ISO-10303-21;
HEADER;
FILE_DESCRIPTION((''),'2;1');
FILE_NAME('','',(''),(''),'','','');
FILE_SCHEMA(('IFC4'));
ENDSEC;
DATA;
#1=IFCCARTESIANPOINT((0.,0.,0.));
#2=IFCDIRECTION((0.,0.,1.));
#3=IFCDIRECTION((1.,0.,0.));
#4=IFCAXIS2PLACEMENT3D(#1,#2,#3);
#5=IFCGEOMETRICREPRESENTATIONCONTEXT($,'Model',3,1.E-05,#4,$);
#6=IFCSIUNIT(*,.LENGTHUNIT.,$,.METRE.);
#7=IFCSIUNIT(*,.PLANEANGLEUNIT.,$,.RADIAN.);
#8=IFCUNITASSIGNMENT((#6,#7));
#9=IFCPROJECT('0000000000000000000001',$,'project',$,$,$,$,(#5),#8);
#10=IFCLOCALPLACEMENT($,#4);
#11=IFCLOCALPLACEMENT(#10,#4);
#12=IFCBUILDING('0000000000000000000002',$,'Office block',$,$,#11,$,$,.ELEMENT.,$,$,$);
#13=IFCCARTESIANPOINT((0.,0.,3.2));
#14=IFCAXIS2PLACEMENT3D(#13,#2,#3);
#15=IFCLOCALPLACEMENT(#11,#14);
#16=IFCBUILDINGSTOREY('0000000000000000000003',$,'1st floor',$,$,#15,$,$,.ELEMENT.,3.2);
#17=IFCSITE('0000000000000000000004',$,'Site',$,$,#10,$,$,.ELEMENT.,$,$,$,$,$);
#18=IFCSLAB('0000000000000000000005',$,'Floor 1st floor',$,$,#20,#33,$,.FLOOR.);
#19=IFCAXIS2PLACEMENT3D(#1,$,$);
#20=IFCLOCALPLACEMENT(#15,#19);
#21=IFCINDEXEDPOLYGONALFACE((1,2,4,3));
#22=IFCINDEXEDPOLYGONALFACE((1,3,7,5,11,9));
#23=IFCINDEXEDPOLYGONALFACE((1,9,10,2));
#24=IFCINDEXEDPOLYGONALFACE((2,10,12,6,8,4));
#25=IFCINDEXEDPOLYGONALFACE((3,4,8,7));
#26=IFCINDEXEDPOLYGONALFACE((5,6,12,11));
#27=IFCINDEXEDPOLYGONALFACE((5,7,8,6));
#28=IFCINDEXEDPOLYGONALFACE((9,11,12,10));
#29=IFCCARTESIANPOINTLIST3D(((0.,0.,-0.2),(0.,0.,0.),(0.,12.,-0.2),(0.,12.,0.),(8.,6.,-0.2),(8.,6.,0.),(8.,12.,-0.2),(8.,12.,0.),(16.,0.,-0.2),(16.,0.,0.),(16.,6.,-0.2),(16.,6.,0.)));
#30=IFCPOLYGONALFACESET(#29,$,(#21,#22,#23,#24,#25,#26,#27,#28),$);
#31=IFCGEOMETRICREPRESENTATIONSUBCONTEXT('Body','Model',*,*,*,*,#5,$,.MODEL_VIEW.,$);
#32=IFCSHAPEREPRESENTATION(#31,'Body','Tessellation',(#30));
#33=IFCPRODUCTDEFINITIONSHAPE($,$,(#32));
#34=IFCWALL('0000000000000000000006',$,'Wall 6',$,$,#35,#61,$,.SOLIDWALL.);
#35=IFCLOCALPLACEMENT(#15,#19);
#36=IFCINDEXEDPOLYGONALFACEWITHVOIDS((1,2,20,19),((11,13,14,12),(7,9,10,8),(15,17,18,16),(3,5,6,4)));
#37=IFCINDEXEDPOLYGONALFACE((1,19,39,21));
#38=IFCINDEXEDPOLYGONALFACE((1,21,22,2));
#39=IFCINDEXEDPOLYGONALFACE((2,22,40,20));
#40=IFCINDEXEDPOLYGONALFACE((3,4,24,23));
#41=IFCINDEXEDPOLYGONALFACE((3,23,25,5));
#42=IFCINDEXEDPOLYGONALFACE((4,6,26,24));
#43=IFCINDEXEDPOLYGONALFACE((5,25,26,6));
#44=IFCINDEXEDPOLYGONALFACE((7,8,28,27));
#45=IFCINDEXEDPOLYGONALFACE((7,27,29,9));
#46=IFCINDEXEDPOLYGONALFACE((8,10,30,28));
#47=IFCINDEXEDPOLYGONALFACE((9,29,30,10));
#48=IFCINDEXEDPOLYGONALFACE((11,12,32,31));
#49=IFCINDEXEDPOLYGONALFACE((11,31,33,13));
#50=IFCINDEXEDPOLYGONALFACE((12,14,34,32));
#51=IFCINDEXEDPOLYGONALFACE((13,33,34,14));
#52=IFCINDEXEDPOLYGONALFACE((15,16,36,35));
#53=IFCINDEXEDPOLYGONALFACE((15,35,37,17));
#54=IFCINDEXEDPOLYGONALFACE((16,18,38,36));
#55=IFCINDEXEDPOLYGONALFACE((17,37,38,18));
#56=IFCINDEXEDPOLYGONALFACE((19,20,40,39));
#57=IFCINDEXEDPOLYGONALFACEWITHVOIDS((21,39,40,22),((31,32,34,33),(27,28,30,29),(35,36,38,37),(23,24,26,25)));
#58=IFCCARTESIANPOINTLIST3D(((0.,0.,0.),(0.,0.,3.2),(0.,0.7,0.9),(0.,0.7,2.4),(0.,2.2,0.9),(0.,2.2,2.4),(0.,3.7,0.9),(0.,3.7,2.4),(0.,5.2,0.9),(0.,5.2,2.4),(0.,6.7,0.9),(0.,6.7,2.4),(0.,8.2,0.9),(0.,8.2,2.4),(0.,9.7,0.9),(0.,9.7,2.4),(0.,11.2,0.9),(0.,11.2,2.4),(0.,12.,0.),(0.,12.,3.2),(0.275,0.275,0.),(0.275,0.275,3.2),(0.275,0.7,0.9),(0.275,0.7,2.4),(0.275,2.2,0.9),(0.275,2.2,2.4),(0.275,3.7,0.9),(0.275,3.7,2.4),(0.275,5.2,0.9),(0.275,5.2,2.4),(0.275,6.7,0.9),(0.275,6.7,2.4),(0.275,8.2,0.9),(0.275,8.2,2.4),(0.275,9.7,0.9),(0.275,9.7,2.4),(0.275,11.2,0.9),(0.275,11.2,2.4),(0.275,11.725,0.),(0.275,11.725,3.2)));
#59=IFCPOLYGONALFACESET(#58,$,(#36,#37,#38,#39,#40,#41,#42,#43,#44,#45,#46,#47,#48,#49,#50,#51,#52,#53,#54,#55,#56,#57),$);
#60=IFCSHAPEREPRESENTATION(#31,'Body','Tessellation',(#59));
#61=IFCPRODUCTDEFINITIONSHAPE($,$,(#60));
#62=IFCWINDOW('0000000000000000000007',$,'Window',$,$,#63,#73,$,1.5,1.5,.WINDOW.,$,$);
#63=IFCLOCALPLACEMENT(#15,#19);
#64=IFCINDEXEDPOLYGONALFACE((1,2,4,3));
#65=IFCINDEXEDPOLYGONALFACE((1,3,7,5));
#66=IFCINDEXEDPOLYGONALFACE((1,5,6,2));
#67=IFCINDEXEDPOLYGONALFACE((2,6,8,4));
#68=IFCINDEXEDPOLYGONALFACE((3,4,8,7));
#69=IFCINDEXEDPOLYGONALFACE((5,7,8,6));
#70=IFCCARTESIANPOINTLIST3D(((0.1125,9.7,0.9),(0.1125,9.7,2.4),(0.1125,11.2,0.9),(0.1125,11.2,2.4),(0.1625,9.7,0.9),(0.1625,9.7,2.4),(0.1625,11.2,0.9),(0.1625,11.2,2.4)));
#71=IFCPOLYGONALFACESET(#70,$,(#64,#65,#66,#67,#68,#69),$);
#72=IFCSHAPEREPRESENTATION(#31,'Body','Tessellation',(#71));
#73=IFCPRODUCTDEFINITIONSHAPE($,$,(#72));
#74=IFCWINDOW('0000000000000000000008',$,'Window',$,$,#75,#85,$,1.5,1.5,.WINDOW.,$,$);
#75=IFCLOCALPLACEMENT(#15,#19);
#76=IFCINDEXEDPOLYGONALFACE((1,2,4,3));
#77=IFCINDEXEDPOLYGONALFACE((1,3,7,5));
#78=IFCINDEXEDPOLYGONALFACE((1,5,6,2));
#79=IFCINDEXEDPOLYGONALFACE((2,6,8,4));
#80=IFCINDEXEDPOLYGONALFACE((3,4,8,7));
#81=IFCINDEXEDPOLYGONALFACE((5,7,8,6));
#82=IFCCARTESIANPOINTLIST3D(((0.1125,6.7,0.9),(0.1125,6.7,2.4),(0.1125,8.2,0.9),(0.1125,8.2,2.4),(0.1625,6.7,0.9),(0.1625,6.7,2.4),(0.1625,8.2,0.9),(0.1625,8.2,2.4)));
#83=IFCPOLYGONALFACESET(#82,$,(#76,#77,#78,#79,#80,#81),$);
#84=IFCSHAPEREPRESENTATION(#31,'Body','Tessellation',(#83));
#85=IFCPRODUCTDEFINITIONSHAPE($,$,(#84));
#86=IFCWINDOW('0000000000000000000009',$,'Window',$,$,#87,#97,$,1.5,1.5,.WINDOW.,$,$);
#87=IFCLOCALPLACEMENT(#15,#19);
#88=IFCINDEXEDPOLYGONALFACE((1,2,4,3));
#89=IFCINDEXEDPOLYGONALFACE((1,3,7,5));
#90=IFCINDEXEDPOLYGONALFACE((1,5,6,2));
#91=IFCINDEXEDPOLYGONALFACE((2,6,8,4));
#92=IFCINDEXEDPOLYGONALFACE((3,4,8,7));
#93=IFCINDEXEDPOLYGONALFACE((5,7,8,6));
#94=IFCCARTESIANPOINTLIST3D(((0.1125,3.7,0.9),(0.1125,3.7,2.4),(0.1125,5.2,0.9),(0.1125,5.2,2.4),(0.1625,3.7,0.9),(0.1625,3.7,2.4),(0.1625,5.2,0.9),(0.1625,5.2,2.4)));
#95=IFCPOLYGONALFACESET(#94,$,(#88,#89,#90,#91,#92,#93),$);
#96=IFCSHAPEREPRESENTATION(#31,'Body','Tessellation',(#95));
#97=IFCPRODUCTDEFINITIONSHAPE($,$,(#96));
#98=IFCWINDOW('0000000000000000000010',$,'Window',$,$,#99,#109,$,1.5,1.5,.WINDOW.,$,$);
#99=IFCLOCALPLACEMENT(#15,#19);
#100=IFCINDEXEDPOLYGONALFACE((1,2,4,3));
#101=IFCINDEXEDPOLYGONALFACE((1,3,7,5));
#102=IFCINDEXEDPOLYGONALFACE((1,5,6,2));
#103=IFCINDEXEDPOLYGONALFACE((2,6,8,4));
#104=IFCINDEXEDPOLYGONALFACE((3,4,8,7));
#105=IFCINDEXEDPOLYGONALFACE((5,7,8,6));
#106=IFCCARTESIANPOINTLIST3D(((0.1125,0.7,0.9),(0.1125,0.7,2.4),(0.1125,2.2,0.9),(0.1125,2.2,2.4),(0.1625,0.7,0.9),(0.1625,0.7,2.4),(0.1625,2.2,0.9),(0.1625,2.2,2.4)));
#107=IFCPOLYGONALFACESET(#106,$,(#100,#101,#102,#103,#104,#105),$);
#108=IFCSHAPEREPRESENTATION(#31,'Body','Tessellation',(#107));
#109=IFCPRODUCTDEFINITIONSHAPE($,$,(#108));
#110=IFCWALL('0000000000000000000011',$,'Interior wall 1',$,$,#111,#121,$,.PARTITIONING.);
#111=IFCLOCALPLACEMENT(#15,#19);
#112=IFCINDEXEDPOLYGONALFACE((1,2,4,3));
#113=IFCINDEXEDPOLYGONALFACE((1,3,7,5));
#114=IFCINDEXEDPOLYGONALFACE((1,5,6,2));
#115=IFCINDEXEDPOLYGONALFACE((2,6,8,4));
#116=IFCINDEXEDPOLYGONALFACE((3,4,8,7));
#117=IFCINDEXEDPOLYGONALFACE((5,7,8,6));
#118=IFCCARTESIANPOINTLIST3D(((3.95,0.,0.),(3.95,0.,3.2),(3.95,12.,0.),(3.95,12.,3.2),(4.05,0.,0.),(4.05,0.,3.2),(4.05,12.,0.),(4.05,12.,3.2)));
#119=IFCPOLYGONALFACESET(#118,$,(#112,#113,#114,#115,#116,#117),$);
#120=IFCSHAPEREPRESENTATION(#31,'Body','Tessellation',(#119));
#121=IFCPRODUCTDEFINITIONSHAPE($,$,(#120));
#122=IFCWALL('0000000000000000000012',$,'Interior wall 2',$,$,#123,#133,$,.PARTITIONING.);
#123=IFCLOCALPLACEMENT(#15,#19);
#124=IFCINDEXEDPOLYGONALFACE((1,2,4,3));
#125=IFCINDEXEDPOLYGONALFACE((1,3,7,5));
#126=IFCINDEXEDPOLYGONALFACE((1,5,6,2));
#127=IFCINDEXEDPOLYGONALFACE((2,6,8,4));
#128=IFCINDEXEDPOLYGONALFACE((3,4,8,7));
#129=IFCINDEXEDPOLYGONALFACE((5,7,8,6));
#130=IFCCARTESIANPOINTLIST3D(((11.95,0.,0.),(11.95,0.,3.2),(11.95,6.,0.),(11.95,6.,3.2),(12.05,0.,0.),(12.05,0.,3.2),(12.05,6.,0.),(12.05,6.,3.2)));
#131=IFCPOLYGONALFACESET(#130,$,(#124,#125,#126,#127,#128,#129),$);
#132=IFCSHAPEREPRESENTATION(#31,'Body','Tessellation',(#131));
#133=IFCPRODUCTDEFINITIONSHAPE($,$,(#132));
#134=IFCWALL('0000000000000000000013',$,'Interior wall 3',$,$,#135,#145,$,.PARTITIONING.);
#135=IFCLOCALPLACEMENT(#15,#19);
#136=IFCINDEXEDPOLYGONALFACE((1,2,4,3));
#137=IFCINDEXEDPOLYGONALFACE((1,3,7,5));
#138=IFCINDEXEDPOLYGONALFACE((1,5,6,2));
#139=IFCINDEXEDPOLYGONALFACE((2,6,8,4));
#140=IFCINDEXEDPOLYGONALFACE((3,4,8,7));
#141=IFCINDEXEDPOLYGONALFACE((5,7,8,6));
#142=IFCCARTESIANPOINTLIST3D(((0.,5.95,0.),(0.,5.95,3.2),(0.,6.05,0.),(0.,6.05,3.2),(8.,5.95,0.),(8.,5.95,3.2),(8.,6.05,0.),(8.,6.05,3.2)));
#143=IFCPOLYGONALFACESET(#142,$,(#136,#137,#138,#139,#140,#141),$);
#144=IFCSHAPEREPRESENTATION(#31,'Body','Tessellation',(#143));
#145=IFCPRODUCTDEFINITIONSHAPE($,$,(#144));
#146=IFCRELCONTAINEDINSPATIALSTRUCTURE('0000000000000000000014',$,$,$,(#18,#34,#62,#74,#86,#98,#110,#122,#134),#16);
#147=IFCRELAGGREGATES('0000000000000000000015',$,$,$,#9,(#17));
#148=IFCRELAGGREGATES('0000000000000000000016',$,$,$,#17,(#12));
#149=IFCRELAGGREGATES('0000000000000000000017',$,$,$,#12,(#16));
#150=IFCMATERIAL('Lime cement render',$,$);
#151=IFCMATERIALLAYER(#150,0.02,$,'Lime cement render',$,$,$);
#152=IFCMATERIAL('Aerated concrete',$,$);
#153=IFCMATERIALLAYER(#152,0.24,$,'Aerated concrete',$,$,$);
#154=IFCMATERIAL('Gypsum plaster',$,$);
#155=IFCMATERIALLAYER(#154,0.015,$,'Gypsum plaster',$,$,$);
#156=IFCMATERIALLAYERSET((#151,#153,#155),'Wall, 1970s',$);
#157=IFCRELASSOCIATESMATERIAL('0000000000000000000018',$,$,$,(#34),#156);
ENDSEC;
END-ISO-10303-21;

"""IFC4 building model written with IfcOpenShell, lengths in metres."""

from ifc_helpers import new_model, si_unit, frame, origin_with_axes, place, context, subcontext, project, spatial, polyline, outline, extrude, material, layer, layer_set, layer_usage, element, fill, save


model = new_model("IFC4")

# Units and contexts
model_context = context("Model", 3, precision=1e-05, world=origin_with_axes())
body_context = subcontext(model_context, "Body", "Model", "MODEL_VIEW")
ifc_project = project(units=[si_unit("LENGTHUNIT", "METRE"), si_unit("PLANEANGLEUNIT", "RADIAN")], contexts=[model_context])

# Site, building, storey
site_placement = place(None, origin_with_axes())
site = spatial("IfcSite", under=ifc_project, at=site_placement, Name="Site", CompositionType="ELEMENT")
building_placement = place(site_placement, origin_with_axes())
building = spatial("IfcBuilding", under=site, at=building_placement, Name="Office block", CompositionType="ELEMENT")
storey_placement = place(building_placement, frame((0.0, 0.0, 3.2), z_axis=(0.0, 0.0, 1.0), x_axis=(1.0, 0.0, 0.0)))
storey = spatial("IfcBuildingStorey", under=building, at=storey_placement, Name="1st floor", CompositionType="ELEMENT", Elevation=3.2)

# Slab
slab_placement = place(storey_placement, origin_with_axes())
element("IfcSlab", 1, at=slab_placement, inside=storey, Name="Floor 1st floor", PredefinedType="FLOOR", context=body_context, shape_type="SweptSolid", body=[
    extrude(outline(polyline([(0.0, 0.0), (16.0, 0.0), (16.0, 6.0), (8.0, 6.0), (8.0, 12.0), (0.0, 12.0), (0.0, 0.0)])), frame((0.0, 0.0, -0.2), z_axis=(0.0, 0.0, 1.0), x_axis=(1.0, 0.0, 0.0)), (0.0, 0.0, 1.0), 0.2),
])

# Wall, openings, windows
ifc_material_1 = material(Name="Lime cement render")
ifc_layer_1 = layer(ifc_material_1, 0.02, Name="Lime cement render")
ifc_material_2 = material(Name="Aerated concrete")
ifc_layer_2 = layer(ifc_material_2, 0.24, Name="Aerated concrete")
ifc_material_3 = material(Name="Gypsum plaster")
ifc_layer_3 = layer(ifc_material_3, 0.015, Name="Gypsum plaster")
ifc_layer_set = layer_set([ifc_layer_1, ifc_layer_2, ifc_layer_3], Name="Wall, 1970s")
ifc_layer_usage = layer_usage(ifc_layer_set, "AXIS2", "NEGATIVE", 0.0)
wall_1_placement = place(storey_placement, origin_with_axes())
wall_1 = element("IfcWall", 2, at=wall_1_placement, inside=storey, material=ifc_layer_usage, Name="Wall 6", PredefinedType="SOLIDWALL", context=body_context, shape_type="SweptSolid", body=[
    extrude(outline(polyline([(0.0, 12.0), (0.0, 0.0), (0.275, 0.275), (0.275, 11.725), (0.0, 12.0)])), origin_with_axes(), (0.0, 0.0, 1.0), 3.2),
])
opening_1_placement = place(storey_placement, origin_with_axes())
opening_1 = element("IfcOpeningElement", 3, at=opening_1_placement, cuts=wall_1, PredefinedType="OPENING", context=body_context, shape_type="SweptSolid", body=[
    extrude(outline(polyline([(-0.01, 11.2), (-0.01, 9.7), (0.285, 9.7), (0.285, 11.2), (-0.01, 11.2)])), frame((0.0, 0.0, 0.9), z_axis=(0.0, 0.0, 1.0), x_axis=(1.0, 0.0, 0.0)), (0.0, 0.0, 1.0), 1.5),
])
opening_2_placement = place(storey_placement, origin_with_axes())
opening_2 = element("IfcOpeningElement", 4, at=opening_2_placement, cuts=wall_1, PredefinedType="OPENING", context=body_context, shape_type="SweptSolid", body=[
    extrude(outline(polyline([(-0.01, 8.2), (-0.01, 6.7), (0.285, 6.7), (0.285, 8.2), (-0.01, 8.2)])), frame((0.0, 0.0, 0.9), z_axis=(0.0, 0.0, 1.0), x_axis=(1.0, 0.0, 0.0)), (0.0, 0.0, 1.0), 1.5),
])
opening_3_placement = place(storey_placement, origin_with_axes())
opening_3 = element("IfcOpeningElement", 5, at=opening_3_placement, cuts=wall_1, PredefinedType="OPENING", context=body_context, shape_type="SweptSolid", body=[
    extrude(outline(polyline([(-0.01, 5.2), (-0.01, 3.7), (0.285, 3.7), (0.285, 5.2), (-0.01, 5.2)])), frame((0.0, 0.0, 0.9), z_axis=(0.0, 0.0, 1.0), x_axis=(1.0, 0.0, 0.0)), (0.0, 0.0, 1.0), 1.5),
])
opening_4_placement = place(storey_placement, origin_with_axes())
opening_4 = element("IfcOpeningElement", 6, at=opening_4_placement, cuts=wall_1, PredefinedType="OPENING", context=body_context, shape_type="SweptSolid", body=[
    extrude(outline(polyline([(-0.01, 2.2), (-0.01, 0.7), (0.285, 0.7), (0.285, 2.2), (-0.01, 2.2)])), frame((0.0, 0.0, 0.9), z_axis=(0.0, 0.0, 1.0), x_axis=(1.0, 0.0, 0.0)), (0.0, 0.0, 1.0), 1.5),
])
window_1_placement = place(storey_placement, origin_with_axes())
window_1 = element("IfcWindow", 7, at=window_1_placement, inside=storey, Name="Window", OverallHeight=1.5, OverallWidth=1.5, PredefinedType="WINDOW", context=body_context, shape_type="SweptSolid", body=[
    extrude(outline(polyline([(0.1125, 11.2), (0.1125, 9.7), (0.1625, 9.7), (0.1625, 11.2), (0.1125, 11.2)])), frame((0.0, 0.0, 0.9), z_axis=(0.0, 0.0, 1.0), x_axis=(1.0, 0.0, 0.0)), (0.0, 0.0, 1.0), 1.5),
])
fill(opening_1, window_1)
window_2_placement = place(storey_placement, origin_with_axes())
window_2 = element("IfcWindow", 8, at=window_2_placement, inside=storey, Name="Window", OverallHeight=1.5, OverallWidth=1.5, PredefinedType="WINDOW", context=body_context, shape_type="SweptSolid", body=[
    extrude(outline(polyline([(0.1125, 8.2), (0.1125, 6.7), (0.1625, 6.7), (0.1625, 8.2), (0.1125, 8.2)])), frame((0.0, 0.0, 0.9), z_axis=(0.0, 0.0, 1.0), x_axis=(1.0, 0.0, 0.0)), (0.0, 0.0, 1.0), 1.5),
])
fill(opening_2, window_2)
window_3_placement = place(storey_placement, origin_with_axes())
window_3 = element("IfcWindow", 9, at=window_3_placement, inside=storey, Name="Window", OverallHeight=1.5, OverallWidth=1.5, PredefinedType="WINDOW", context=body_context, shape_type="SweptSolid", body=[
    extrude(outline(polyline([(0.1125, 5.2), (0.1125, 3.7), (0.1625, 3.7), (0.1625, 5.2), (0.1125, 5.2)])), frame((0.0, 0.0, 0.9), z_axis=(0.0, 0.0, 1.0), x_axis=(1.0, 0.0, 0.0)), (0.0, 0.0, 1.0), 1.5),
])
fill(opening_3, window_3)
window_4_placement = place(storey_placement, origin_with_axes())
window_4 = element("IfcWindow", 10, at=window_4_placement, inside=storey, Name="Window", OverallHeight=1.5, OverallWidth=1.5, PredefinedType="WINDOW", context=body_context, shape_type="SweptSolid", body=[
    extrude(outline(polyline([(0.1125, 2.2), (0.1125, 0.7), (0.1625, 0.7), (0.1625, 2.2), (0.1125, 2.2)])), frame((0.0, 0.0, 0.9), z_axis=(0.0, 0.0, 1.0), x_axis=(1.0, 0.0, 0.0)), (0.0, 0.0, 1.0), 1.5),
])
fill(opening_4, window_4)

# Walls
wall_2_placement = place(storey_placement, origin_with_axes())
element("IfcWall", 11, at=wall_2_placement, inside=storey, Name="Interior wall 1", PredefinedType="PARTITIONING", context=body_context, shape_type="SweptSolid", body=[
    extrude(outline(polyline([(3.95, 0.0), (3.95, 12.0), (4.05, 12.0), (4.05, 0.0), (3.95, 0.0)])), origin_with_axes(), (0.0, 0.0, 1.0), 3.2),
])
wall_3_placement = place(storey_placement, origin_with_axes())
element("IfcWall", 12, at=wall_3_placement, inside=storey, Name="Interior wall 2", PredefinedType="PARTITIONING", context=body_context, shape_type="SweptSolid", body=[
    extrude(outline(polyline([(11.95, 0.0), (11.95, 6.0), (12.05, 6.0), (12.05, 0.0), (11.95, 0.0)])), origin_with_axes(), (0.0, 0.0, 1.0), 3.2),
])
wall_4_placement = place(storey_placement, origin_with_axes())
element("IfcWall", 13, at=wall_4_placement, inside=storey, Name="Interior wall 3", PredefinedType="PARTITIONING", context=body_context, shape_type="SweptSolid", body=[
    extrude(outline(polyline([(0.0, 6.05), (8.0, 6.05), (8.0, 5.95), (0.0, 5.95), (0.0, 6.05)])), origin_with_axes(), (0.0, 0.0, 1.0), 3.2),
])

save(model, "model.ifc")
